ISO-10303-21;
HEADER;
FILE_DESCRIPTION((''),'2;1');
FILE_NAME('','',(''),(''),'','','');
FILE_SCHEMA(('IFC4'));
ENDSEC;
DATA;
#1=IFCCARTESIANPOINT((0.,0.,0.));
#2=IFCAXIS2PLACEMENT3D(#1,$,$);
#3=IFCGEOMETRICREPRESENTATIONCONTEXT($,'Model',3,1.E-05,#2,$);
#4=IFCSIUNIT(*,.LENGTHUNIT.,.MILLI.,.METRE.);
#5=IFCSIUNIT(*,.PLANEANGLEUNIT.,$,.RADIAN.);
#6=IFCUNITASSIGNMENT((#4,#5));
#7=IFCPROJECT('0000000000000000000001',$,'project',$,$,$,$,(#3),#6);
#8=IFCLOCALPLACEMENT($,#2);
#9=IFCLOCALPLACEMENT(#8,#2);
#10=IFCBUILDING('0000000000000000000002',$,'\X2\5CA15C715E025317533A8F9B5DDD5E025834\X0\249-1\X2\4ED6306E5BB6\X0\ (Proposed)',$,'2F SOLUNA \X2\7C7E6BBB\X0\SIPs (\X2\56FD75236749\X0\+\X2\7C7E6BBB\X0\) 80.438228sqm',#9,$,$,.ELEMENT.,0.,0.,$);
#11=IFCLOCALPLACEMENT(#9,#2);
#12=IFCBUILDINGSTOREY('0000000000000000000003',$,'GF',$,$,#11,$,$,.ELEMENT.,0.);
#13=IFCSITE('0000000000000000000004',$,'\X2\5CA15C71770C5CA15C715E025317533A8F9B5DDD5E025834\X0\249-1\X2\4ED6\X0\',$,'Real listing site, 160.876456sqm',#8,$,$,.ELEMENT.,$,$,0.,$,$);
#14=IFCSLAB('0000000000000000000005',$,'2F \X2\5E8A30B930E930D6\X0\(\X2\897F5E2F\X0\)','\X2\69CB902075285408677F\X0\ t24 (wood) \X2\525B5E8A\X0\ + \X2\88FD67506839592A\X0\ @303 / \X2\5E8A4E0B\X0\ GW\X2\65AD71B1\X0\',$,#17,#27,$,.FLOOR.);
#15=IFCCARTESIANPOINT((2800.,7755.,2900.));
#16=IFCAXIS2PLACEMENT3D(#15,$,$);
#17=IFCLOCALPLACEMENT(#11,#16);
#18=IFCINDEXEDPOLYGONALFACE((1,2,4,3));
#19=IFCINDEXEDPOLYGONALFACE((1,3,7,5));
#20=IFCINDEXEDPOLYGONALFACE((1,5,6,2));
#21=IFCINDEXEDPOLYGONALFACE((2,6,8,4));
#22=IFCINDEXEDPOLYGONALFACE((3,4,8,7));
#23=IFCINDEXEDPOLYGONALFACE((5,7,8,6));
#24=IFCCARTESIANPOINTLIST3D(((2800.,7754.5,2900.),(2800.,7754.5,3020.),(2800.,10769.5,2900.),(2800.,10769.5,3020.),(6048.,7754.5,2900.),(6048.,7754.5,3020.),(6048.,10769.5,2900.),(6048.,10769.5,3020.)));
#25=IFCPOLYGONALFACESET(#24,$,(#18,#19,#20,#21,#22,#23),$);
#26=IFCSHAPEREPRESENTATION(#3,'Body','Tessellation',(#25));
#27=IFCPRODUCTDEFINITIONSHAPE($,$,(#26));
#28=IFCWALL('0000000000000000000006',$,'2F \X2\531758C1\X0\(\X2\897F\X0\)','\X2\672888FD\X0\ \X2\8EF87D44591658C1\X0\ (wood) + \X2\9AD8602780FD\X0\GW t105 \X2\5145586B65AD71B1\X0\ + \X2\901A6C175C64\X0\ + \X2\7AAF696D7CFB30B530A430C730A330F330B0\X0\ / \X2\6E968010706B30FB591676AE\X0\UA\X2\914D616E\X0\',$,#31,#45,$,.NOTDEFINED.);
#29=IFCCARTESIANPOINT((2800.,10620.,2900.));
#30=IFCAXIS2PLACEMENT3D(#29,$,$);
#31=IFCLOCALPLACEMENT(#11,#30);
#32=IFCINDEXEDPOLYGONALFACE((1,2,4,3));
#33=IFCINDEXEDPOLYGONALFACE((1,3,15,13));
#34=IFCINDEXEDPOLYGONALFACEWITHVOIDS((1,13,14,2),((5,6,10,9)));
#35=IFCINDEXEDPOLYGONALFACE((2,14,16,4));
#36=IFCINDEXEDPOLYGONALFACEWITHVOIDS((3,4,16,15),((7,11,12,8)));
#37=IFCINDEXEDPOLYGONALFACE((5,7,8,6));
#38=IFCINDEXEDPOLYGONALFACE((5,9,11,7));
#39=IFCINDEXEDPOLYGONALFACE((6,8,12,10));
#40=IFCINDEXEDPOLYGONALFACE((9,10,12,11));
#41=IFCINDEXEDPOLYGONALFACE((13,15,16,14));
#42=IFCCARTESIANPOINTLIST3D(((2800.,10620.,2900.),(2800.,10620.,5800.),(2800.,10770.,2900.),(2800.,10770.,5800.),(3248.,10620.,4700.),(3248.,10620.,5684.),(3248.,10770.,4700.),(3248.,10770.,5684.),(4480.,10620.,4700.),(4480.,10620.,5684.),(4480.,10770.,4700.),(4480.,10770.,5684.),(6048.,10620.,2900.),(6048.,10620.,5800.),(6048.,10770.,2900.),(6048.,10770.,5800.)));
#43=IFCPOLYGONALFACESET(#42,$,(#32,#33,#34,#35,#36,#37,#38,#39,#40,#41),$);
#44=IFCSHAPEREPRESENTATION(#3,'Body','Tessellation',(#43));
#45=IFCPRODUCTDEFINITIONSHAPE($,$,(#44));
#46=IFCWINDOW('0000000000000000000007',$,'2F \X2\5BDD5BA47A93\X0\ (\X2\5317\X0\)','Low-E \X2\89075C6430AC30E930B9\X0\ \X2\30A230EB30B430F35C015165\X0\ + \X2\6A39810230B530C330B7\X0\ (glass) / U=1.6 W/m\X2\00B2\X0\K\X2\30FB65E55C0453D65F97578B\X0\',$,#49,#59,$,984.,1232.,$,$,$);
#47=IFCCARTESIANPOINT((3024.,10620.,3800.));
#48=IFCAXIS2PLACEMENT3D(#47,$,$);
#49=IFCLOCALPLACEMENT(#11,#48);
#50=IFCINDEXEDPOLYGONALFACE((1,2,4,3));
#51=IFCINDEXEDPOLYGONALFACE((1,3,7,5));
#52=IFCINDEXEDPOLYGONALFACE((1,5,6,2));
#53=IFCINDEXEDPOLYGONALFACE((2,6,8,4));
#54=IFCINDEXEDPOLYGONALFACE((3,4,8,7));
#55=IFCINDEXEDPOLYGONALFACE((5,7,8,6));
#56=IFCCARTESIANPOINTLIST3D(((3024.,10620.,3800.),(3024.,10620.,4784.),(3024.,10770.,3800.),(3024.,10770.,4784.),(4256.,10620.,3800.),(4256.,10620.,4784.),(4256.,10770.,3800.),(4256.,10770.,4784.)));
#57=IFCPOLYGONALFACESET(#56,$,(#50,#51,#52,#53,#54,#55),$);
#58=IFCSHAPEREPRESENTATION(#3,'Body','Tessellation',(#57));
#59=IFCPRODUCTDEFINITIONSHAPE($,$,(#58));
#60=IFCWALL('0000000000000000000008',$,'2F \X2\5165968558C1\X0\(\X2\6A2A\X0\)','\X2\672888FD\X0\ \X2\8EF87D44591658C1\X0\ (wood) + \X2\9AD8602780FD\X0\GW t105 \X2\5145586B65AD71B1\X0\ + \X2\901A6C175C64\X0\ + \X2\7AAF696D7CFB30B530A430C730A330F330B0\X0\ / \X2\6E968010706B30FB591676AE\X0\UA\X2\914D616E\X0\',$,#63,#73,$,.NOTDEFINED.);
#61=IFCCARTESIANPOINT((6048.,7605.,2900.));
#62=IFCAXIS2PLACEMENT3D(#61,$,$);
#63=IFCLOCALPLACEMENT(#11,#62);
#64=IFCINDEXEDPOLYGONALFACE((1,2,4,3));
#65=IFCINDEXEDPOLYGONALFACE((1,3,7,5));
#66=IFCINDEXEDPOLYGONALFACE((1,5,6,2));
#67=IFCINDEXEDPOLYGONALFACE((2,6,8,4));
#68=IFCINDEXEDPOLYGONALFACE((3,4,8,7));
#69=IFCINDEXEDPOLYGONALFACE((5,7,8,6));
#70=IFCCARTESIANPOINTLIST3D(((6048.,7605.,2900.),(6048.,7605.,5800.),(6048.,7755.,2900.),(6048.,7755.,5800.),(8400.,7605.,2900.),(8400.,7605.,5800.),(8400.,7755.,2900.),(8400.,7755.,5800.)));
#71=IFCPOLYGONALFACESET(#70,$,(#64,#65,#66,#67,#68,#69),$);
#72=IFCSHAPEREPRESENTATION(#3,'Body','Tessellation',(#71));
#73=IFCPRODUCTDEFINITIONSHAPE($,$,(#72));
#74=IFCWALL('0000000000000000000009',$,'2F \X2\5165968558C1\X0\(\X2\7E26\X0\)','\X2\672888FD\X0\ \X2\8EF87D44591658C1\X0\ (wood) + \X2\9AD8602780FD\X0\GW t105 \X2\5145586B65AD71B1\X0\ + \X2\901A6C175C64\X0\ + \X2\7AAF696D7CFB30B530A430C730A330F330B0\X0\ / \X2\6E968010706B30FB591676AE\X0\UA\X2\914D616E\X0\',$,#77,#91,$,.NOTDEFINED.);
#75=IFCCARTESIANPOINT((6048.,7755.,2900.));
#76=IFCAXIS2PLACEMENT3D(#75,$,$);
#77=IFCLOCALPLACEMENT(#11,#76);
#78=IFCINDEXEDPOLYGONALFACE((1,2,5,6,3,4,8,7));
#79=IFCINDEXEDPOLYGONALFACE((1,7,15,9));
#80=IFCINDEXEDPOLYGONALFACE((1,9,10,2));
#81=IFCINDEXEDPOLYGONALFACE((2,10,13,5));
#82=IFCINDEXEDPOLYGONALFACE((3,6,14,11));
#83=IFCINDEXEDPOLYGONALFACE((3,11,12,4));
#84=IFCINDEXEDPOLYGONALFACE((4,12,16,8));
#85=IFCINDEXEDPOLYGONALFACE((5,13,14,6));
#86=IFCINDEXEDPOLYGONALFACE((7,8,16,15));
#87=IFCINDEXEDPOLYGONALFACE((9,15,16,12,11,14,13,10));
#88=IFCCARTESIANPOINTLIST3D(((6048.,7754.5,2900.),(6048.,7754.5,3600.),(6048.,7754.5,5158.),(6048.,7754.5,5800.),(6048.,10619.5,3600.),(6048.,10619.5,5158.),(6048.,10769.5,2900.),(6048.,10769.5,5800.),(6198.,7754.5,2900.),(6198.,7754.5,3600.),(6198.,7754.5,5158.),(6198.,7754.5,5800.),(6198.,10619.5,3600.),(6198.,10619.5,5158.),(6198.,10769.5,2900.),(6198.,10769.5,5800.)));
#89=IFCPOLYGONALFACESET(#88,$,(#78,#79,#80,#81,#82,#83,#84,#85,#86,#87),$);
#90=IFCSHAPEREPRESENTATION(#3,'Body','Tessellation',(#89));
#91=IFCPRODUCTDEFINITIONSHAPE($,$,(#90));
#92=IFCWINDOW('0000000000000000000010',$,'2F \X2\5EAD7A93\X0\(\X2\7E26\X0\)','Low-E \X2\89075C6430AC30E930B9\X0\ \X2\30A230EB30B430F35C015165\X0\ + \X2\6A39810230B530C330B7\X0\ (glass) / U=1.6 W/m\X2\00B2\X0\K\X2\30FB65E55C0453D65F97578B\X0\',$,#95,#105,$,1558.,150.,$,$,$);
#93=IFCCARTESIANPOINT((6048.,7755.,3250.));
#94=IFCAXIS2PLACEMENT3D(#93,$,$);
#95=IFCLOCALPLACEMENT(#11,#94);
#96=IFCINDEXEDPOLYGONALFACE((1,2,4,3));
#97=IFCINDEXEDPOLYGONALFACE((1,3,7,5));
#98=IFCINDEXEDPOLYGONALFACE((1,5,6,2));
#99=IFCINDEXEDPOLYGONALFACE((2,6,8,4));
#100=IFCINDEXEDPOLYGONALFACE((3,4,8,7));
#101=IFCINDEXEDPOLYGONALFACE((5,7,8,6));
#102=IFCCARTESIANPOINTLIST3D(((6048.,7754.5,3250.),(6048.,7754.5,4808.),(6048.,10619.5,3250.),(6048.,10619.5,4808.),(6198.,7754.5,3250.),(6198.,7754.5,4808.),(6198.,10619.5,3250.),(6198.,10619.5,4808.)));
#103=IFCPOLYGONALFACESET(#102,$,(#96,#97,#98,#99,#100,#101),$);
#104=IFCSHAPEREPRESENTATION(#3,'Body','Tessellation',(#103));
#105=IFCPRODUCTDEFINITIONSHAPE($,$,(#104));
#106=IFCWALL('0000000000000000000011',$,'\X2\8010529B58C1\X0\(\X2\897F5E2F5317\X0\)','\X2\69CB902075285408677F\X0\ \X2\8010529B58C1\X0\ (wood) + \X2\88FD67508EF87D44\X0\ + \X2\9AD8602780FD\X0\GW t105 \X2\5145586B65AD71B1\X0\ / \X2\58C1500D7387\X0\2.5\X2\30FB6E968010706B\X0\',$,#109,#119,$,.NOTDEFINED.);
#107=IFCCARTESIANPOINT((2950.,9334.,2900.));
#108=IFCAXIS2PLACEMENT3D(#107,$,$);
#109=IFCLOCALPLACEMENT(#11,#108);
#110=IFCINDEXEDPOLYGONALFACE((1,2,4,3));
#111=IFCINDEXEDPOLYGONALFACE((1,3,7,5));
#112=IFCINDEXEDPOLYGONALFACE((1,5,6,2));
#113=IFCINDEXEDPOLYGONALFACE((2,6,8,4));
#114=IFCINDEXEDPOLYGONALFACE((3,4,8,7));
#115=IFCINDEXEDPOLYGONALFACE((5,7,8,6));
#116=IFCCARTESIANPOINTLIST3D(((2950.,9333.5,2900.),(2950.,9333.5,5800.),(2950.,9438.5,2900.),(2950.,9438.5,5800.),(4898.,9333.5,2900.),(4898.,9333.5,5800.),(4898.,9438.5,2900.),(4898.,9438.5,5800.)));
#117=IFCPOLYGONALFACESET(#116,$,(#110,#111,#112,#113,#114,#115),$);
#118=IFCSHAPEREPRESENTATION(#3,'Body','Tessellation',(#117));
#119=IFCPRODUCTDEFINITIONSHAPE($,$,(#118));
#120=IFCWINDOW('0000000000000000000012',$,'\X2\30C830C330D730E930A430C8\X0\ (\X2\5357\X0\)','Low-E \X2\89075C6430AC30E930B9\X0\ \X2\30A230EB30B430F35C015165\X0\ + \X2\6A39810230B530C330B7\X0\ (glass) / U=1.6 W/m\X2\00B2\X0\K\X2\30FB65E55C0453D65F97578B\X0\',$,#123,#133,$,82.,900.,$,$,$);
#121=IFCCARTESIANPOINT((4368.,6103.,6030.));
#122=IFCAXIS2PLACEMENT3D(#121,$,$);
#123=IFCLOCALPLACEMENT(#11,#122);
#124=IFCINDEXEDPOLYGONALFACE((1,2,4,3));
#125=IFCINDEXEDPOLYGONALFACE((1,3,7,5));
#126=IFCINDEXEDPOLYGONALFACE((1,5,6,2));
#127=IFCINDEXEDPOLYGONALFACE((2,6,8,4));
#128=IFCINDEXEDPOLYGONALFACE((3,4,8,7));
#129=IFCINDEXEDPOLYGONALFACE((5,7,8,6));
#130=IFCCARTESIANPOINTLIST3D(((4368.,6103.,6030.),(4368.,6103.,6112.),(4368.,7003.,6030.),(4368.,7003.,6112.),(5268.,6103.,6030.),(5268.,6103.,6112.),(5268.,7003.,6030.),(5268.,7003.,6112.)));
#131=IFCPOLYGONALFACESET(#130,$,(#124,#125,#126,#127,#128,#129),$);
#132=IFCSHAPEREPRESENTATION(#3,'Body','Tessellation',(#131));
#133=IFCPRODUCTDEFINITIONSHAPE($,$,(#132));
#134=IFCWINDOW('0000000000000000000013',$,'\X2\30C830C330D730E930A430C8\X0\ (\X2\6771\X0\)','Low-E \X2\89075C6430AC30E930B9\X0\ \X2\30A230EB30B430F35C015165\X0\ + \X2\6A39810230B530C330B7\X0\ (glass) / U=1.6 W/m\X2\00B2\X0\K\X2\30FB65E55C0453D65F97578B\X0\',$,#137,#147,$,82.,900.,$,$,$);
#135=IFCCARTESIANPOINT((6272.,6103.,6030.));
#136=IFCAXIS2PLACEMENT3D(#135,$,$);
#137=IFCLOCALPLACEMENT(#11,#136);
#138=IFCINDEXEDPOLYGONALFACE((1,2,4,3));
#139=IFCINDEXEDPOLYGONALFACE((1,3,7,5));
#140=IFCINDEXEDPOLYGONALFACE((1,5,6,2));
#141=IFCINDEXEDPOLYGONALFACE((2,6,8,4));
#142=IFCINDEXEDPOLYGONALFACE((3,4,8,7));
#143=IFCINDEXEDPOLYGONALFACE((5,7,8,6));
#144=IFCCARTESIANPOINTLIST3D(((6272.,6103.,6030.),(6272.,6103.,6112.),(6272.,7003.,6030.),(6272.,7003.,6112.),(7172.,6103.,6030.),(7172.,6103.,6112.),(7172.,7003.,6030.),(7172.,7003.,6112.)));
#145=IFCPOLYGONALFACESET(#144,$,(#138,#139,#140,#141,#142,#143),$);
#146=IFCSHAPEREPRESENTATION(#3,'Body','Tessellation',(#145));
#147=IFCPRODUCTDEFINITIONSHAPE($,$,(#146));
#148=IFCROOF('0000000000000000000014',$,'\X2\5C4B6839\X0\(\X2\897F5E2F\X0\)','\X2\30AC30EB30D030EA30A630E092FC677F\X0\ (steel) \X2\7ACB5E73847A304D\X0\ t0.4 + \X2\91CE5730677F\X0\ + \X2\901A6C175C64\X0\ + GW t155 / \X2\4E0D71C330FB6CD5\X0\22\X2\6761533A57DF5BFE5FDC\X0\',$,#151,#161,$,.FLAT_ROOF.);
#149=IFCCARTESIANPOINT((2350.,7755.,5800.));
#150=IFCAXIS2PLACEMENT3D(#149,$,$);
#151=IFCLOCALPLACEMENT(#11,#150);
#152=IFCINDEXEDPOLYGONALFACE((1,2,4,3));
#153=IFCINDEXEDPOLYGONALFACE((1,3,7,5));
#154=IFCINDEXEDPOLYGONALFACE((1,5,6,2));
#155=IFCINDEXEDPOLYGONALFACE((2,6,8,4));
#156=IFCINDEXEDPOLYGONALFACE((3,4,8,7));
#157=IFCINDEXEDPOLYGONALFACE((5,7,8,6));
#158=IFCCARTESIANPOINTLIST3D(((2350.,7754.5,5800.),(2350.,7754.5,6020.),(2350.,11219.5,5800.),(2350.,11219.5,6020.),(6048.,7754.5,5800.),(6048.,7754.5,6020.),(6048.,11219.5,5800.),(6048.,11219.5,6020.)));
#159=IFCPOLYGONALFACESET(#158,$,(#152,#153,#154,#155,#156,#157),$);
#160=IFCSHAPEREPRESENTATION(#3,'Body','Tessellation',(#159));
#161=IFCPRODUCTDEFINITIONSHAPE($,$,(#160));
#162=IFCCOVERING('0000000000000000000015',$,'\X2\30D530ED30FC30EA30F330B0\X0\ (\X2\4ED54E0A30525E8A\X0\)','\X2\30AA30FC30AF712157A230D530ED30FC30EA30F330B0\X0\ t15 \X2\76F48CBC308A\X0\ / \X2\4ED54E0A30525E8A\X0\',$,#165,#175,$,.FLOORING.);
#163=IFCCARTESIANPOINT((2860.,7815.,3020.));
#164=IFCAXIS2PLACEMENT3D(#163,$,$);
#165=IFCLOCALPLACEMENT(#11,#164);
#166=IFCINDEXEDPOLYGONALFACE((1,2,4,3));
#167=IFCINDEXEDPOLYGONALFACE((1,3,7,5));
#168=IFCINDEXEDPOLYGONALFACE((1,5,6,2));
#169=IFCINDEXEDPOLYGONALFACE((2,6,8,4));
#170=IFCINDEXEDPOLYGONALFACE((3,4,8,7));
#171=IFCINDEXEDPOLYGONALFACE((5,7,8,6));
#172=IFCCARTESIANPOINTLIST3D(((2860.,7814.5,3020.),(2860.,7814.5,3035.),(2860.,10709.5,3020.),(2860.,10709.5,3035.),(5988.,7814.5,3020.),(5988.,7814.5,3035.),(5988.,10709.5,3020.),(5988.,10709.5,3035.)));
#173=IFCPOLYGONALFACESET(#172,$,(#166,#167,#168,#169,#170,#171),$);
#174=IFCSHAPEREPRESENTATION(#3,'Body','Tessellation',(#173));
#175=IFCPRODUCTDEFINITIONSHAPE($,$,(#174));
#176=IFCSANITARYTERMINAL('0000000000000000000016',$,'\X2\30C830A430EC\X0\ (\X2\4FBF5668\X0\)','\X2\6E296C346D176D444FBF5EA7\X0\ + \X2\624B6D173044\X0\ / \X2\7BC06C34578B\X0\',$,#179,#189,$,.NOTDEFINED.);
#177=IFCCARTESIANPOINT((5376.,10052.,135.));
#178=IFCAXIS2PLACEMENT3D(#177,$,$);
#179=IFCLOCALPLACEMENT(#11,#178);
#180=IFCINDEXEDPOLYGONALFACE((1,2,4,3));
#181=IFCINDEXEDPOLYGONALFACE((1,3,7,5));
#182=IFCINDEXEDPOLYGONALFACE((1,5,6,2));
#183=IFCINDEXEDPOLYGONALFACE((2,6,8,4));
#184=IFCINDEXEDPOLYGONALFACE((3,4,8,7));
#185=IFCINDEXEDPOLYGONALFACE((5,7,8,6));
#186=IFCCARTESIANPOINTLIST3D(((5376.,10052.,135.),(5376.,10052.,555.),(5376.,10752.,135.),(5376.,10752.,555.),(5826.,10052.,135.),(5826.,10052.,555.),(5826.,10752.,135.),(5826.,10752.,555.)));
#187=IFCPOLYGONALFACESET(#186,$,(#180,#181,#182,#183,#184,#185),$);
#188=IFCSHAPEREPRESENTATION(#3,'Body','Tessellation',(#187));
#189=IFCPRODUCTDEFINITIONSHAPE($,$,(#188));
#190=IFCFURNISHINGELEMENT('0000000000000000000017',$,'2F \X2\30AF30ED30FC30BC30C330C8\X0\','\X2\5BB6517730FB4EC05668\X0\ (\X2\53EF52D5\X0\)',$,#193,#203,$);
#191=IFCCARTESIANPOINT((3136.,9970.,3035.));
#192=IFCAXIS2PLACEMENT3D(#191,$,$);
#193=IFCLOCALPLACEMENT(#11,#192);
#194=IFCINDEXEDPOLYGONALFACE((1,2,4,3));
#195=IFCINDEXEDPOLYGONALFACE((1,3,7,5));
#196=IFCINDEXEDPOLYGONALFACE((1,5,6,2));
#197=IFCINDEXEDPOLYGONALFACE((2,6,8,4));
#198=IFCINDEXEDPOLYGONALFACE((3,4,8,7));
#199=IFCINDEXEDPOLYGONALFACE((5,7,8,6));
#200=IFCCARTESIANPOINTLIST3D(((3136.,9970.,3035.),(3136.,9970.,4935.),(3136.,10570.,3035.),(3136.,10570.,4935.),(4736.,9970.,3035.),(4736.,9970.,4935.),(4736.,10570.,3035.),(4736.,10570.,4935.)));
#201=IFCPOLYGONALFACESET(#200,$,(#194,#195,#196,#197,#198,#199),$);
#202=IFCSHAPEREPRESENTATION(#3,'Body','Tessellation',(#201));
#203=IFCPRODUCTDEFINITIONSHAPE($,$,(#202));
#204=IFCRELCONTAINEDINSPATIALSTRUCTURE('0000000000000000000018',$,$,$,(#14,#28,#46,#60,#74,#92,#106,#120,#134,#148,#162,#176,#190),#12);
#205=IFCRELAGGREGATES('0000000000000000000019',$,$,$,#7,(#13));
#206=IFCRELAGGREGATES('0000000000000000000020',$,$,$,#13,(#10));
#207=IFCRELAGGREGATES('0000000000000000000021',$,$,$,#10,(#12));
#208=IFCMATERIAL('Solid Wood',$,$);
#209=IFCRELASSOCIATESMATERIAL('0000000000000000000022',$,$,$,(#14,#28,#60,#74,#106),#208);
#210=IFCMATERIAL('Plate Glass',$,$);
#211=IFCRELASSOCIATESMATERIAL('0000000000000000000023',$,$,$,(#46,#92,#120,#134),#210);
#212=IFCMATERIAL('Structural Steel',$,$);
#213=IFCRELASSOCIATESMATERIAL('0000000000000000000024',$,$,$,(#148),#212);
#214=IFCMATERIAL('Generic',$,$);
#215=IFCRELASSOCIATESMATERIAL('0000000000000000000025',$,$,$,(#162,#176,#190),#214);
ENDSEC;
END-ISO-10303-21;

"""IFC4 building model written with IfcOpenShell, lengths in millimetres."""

from ifc_helpers import new_model, si_unit, frame, frame_2d, origin, place, context, project, spatial, rectangle, extrude, material, element, fill, save


model = new_model("IFC4")

# Units and contexts
model_context = context("Model", 3, precision=1e-05, world=origin())
ifc_project = project(units=[si_unit("LENGTHUNIT", "METRE", prefix="MILLI"), si_unit("PLANEANGLEUNIT", "RADIAN")], contexts=[model_context])

# Site, building, storey
site_placement = place(None, origin())
site = spatial("IfcSite", under=ifc_project, at=site_placement, Name="岡山県岡山市北区辛川市場249-1他", ObjectType="Real listing site, 160.876456sqm", CompositionType="ELEMENT", RefElevation=0.0)
building_placement = place(site_placement, origin())
building = spatial("IfcBuilding", under=site, at=building_placement, Name="岡山市北区辛川市場249-1他の家 (Proposed)", ObjectType="2F SOLUNA 籾殻SIPs (国産杉+籾殻) 80.438228sqm", CompositionType="ELEMENT", ElevationOfRefHeight=0.0, ElevationOfTerrain=0.0)
storey_placement = place(building_placement, origin())
storey = spatial("IfcBuildingStorey", under=building, at=storey_placement, Name="GF", CompositionType="ELEMENT", Elevation=0.0)

# Slab
ifc_material_1 = material(Name="Solid Wood")
slab_placement = place(storey_placement, frame((2800.0, 7755.0, 2900.0)))
element("IfcSlab", 1, at=slab_placement, inside=storey, material=ifc_material_1, Name="2F 床スラブ(西帯)", Description="構造用合板 t24 (wood) 剛床 + 製材根太 @303 / 床下 GW断熱", PredefinedType="FLOOR", context=model_context, shape_type="SweptSolid", body=[
    extrude(rectangle(XDim=3248.0, YDim=3015.0, at=frame_2d((1624.0, 1507.0))), frame((2800.0, 7755.0, 2900.0)), (0.0, 0.0, 1.0), 120.0),
])

# Wall, opening, window
wall_1_placement = place(storey_placement, frame((2800.0, 10620.0, 2900.0)))
wall_1 = element("IfcWall", 2, at=wall_1_placement, inside=storey, material=ifc_material_1, Name="2F 北壁(西)", Description="木製 軸組外壁 (wood) + 高性能GW t105 充填断熱 + 通気層 + 窯業系サイディング / 準耐火・外皮UA配慮", PredefinedType="NOTDEFINED", context=model_context, shape_type="SweptSolid", body=[
    extrude(rectangle(XDim=3248.0, YDim=150.0, at=frame_2d((1624.0, 75.0))), frame((2800.0, 10620.0, 2900.0)), (0.0, 0.0, 1.0), 2900.0),
])
opening_1_placement = place(storey_placement, frame((3024.0, 10620.0, 3800.0)))
opening_1 = element("IfcOpeningElement", 3, at=opening_1_placement, cuts=wall_1, PredefinedType="NOTDEFINED", context=model_context, shape_type="SweptSolid", body=[
    extrude(rectangle(XDim=1232.0, YDim=150.0, at=frame_2d((616.0, 75.0))), frame((3024.0, 10620.0, 3800.0)), (0.0, 0.0, 1.0), 984.0),
])
ifc_material_2 = material(Name="Plate Glass")
window_1_placement = place(storey_placement, frame((3024.0, 10620.0, 3800.0)))
window_1 = element("IfcWindow", 4, at=window_1_placement, inside=storey, material=ifc_material_2, Name="2F 寝室窓 (北)", Description="Low-E 複層ガラス アルゴン封入 + 樹脂サッシ (glass) / U=1.6 W/m²K・日射取得型", OverallHeight=984.0, OverallWidth=1232.0, context=model_context, shape_type="SweptSolid", body=[
    extrude(rectangle(XDim=1232.0, YDim=150.0, at=frame_2d((616.0, 75.0))), frame((3024.0, 10620.0, 3800.0)), (0.0, 0.0, 1.0), 984.0),
])
fill(opening_1, window_1)

# Wall
wall_2_placement = place(storey_placement, frame((6048.0, 7605.0, 2900.0)))
element("IfcWall", 5, at=wall_2_placement, inside=storey, material=ifc_material_1, Name="2F 入隅壁(横)", Description="木製 軸組外壁 (wood) + 高性能GW t105 充填断熱 + 通気層 + 窯業系サイディング / 準耐火・外皮UA配慮", PredefinedType="NOTDEFINED", context=model_context, shape_type="SweptSolid", body=[
    extrude(rectangle(XDim=2352.0, YDim=150.0, at=frame_2d((1176.0, 75.0))), frame((6048.0, 7605.0, 2900.0)), (0.0, 0.0, 1.0), 2900.0),
])

# Wall, opening, window
wall_3_placement = place(storey_placement, frame((6048.0, 7755.0, 2900.0)))
wall_3 = element("IfcWall", 6, at=wall_3_placement, inside=storey, material=ifc_material_1, Name="2F 入隅壁(縦)", Description="木製 軸組外壁 (wood) + 高性能GW t105 充填断熱 + 通気層 + 窯業系サイディング / 準耐火・外皮UA配慮", PredefinedType="NOTDEFINED", context=model_context, shape_type="SweptSolid", body=[
    extrude(rectangle(XDim=150.0, YDim=3015.0, at=frame_2d((75.0, 1507.0))), frame((6048.0, 7755.0, 2900.0)), (0.0, 0.0, 1.0), 2900.0),
])
opening_2_placement = place(storey_placement, frame((6048.0, 7755.0, 3250.0)))
opening_2 = element("IfcOpeningElement", 7, at=opening_2_placement, cuts=wall_3, PredefinedType="NOTDEFINED", context=model_context, shape_type="SweptSolid", body=[
    extrude(rectangle(XDim=150.0, YDim=2865.0, at=frame_2d((75.0, 1432.0))), frame((6048.0, 7755.0, 3250.0)), (0.0, 0.0, 1.0), 1558.0),
])
window_2_placement = place(storey_placement, frame((6048.0, 7755.0, 3250.0)))
window_2 = element("IfcWindow", 8, at=window_2_placement, inside=storey, material=ifc_material_2, Name="2F 庭窓(縦)", Description="Low-E 複層ガラス アルゴン封入 + 樹脂サッシ (glass) / U=1.6 W/m²K・日射取得型", OverallHeight=1558.0, OverallWidth=150.0, context=model_context, shape_type="SweptSolid", body=[
    extrude(rectangle(XDim=150.0, YDim=2865.0, at=frame_2d((75.0, 1432.0))), frame((6048.0, 7755.0, 3250.0)), (0.0, 0.0, 1.0), 1558.0),
])
fill(opening_2, window_2)

# Wall
wall_4_placement = place(storey_placement, frame((2950.0, 9334.0, 2900.0)))
element("IfcWall", 9, at=wall_4_placement, inside=storey, material=ifc_material_1, Name="耐力壁(西帯北)", Description="構造用合板 耐力壁 (wood) + 製材軸組 + 高性能GW t105 充填断熱 / 壁倍率2.5・準耐火", PredefinedType="NOTDEFINED", context=model_context, shape_type="SweptSolid", body=[
    extrude(rectangle(XDim=1948.0, YDim=105.0, at=frame_2d((974.0, 52.0))), frame((2950.0, 9334.0, 2900.0)), (0.0, 0.0, 1.0), 2900.0),
])

# Windows
window_3_placement = place(storey_placement, frame((4368.0, 6103.0, 6030.0)))
element("IfcWindow", 10, at=window_3_placement, inside=storey, material=ifc_material_2, Name="トップライト (南)", Description="Low-E 複層ガラス アルゴン封入 + 樹脂サッシ (glass) / U=1.6 W/m²K・日射取得型", OverallHeight=82.0, OverallWidth=900.0, context=model_context, shape_type="SweptSolid", body=[
    extrude(rectangle(XDim=900.0, YDim=900.0, at=frame_2d((450.0, 450.0))), frame((4368.0, 6103.0, 6030.0)), (0.0, 0.0, 1.0), 82.0),
])
window_4_placement = place(storey_placement, frame((6272.0, 6103.0, 6030.0)))
element("IfcWindow", 11, at=window_4_placement, inside=storey, material=ifc_material_2, Name="トップライト (東)", Description="Low-E 複層ガラス アルゴン封入 + 樹脂サッシ (glass) / U=1.6 W/m²K・日射取得型", OverallHeight=82.0, OverallWidth=900.0, context=model_context, shape_type="SweptSolid", body=[
    extrude(rectangle(XDim=900.0, YDim=900.0, at=frame_2d((450.0, 450.0))), frame((6272.0, 6103.0, 6030.0)), (0.0, 0.0, 1.0), 82.0),
])

# Roof
ifc_material_3 = material(Name="Structural Steel")
for number, where, name in (
    (12, (2350.0, 7755.0, 5800.0), "屋根(西帯)"),
):
    element("IfcRoof", number, at=place(storey_placement, frame(where)), inside=storey, material=ifc_material_3, Name=name, Description="ガルバリウム鋼板 (steel) 立平葺き t0.4 + 野地板 + 通気層 + GW t155 / 不燃・法22条区域対応", PredefinedType="FLAT_ROOF", context=model_context, shape_type="SweptSolid", body=[
        extrude(rectangle(XDim=3698.0, YDim=3465.0, at=frame_2d((1849.0, 1732.0))), frame((2350.0, 7755.0, 5800.0)), (0.0, 0.0, 1.0), 220.0),
    ])

# Covering
ifc_material_4 = material(Name="Generic")
covering_placement = place(storey_placement, frame((2860.0, 7815.0, 3020.0)))
element("IfcCovering", 13, at=covering_placement, inside=storey, material=ifc_material_4, Name="フローリング (仕上げ床)", Description="オーク無垢フローリング t15 直貼り / 仕上げ床", PredefinedType="FLOORING", context=model_context, shape_type="SweptSolid", body=[
    extrude(rectangle(XDim=3128.0, YDim=2895.0, at=frame_2d((1564.0, 1447.0))), frame((2860.0, 7815.0, 3020.0)), (0.0, 0.0, 1.0), 15.0),
])

# Sanitary terminal
sanitary_terminal_placement = place(storey_placement, frame((5376.0, 10052.0, 135.0)))
element("IfcSanitaryTerminal", 14, at=sanitary_terminal_placement, inside=storey, material=ifc_material_4, Name="トイレ (便器)", Description="温水洗浄便座 + 手洗い / 節水型", PredefinedType="NOTDEFINED", context=model_context, shape_type="SweptSolid", body=[
    extrude(rectangle(XDim=450.0, YDim=700.0, at=frame_2d((225.0, 350.0))), frame((5376.0, 10052.0, 135.0)), (0.0, 0.0, 1.0), 420.0),
])

# Furnishing element
furnishing_1_placement = place(storey_placement, frame((3136.0, 9970.0, 3035.0)))
element("IfcFurnishingElement", 15, at=furnishing_1_placement, inside=storey, material=ifc_material_4, Name="2F クローゼット", Description="家具・什器 (可動)", context=model_context, shape_type="SweptSolid", body=[
    extrude(rectangle(XDim=1600.0, YDim=600.0, at=frame_2d((800.0, 300.0))), frame((3136.0, 9970.0, 3035.0)), (0.0, 0.0, 1.0), 1900.0),
])

save(model, "model.ifc")
